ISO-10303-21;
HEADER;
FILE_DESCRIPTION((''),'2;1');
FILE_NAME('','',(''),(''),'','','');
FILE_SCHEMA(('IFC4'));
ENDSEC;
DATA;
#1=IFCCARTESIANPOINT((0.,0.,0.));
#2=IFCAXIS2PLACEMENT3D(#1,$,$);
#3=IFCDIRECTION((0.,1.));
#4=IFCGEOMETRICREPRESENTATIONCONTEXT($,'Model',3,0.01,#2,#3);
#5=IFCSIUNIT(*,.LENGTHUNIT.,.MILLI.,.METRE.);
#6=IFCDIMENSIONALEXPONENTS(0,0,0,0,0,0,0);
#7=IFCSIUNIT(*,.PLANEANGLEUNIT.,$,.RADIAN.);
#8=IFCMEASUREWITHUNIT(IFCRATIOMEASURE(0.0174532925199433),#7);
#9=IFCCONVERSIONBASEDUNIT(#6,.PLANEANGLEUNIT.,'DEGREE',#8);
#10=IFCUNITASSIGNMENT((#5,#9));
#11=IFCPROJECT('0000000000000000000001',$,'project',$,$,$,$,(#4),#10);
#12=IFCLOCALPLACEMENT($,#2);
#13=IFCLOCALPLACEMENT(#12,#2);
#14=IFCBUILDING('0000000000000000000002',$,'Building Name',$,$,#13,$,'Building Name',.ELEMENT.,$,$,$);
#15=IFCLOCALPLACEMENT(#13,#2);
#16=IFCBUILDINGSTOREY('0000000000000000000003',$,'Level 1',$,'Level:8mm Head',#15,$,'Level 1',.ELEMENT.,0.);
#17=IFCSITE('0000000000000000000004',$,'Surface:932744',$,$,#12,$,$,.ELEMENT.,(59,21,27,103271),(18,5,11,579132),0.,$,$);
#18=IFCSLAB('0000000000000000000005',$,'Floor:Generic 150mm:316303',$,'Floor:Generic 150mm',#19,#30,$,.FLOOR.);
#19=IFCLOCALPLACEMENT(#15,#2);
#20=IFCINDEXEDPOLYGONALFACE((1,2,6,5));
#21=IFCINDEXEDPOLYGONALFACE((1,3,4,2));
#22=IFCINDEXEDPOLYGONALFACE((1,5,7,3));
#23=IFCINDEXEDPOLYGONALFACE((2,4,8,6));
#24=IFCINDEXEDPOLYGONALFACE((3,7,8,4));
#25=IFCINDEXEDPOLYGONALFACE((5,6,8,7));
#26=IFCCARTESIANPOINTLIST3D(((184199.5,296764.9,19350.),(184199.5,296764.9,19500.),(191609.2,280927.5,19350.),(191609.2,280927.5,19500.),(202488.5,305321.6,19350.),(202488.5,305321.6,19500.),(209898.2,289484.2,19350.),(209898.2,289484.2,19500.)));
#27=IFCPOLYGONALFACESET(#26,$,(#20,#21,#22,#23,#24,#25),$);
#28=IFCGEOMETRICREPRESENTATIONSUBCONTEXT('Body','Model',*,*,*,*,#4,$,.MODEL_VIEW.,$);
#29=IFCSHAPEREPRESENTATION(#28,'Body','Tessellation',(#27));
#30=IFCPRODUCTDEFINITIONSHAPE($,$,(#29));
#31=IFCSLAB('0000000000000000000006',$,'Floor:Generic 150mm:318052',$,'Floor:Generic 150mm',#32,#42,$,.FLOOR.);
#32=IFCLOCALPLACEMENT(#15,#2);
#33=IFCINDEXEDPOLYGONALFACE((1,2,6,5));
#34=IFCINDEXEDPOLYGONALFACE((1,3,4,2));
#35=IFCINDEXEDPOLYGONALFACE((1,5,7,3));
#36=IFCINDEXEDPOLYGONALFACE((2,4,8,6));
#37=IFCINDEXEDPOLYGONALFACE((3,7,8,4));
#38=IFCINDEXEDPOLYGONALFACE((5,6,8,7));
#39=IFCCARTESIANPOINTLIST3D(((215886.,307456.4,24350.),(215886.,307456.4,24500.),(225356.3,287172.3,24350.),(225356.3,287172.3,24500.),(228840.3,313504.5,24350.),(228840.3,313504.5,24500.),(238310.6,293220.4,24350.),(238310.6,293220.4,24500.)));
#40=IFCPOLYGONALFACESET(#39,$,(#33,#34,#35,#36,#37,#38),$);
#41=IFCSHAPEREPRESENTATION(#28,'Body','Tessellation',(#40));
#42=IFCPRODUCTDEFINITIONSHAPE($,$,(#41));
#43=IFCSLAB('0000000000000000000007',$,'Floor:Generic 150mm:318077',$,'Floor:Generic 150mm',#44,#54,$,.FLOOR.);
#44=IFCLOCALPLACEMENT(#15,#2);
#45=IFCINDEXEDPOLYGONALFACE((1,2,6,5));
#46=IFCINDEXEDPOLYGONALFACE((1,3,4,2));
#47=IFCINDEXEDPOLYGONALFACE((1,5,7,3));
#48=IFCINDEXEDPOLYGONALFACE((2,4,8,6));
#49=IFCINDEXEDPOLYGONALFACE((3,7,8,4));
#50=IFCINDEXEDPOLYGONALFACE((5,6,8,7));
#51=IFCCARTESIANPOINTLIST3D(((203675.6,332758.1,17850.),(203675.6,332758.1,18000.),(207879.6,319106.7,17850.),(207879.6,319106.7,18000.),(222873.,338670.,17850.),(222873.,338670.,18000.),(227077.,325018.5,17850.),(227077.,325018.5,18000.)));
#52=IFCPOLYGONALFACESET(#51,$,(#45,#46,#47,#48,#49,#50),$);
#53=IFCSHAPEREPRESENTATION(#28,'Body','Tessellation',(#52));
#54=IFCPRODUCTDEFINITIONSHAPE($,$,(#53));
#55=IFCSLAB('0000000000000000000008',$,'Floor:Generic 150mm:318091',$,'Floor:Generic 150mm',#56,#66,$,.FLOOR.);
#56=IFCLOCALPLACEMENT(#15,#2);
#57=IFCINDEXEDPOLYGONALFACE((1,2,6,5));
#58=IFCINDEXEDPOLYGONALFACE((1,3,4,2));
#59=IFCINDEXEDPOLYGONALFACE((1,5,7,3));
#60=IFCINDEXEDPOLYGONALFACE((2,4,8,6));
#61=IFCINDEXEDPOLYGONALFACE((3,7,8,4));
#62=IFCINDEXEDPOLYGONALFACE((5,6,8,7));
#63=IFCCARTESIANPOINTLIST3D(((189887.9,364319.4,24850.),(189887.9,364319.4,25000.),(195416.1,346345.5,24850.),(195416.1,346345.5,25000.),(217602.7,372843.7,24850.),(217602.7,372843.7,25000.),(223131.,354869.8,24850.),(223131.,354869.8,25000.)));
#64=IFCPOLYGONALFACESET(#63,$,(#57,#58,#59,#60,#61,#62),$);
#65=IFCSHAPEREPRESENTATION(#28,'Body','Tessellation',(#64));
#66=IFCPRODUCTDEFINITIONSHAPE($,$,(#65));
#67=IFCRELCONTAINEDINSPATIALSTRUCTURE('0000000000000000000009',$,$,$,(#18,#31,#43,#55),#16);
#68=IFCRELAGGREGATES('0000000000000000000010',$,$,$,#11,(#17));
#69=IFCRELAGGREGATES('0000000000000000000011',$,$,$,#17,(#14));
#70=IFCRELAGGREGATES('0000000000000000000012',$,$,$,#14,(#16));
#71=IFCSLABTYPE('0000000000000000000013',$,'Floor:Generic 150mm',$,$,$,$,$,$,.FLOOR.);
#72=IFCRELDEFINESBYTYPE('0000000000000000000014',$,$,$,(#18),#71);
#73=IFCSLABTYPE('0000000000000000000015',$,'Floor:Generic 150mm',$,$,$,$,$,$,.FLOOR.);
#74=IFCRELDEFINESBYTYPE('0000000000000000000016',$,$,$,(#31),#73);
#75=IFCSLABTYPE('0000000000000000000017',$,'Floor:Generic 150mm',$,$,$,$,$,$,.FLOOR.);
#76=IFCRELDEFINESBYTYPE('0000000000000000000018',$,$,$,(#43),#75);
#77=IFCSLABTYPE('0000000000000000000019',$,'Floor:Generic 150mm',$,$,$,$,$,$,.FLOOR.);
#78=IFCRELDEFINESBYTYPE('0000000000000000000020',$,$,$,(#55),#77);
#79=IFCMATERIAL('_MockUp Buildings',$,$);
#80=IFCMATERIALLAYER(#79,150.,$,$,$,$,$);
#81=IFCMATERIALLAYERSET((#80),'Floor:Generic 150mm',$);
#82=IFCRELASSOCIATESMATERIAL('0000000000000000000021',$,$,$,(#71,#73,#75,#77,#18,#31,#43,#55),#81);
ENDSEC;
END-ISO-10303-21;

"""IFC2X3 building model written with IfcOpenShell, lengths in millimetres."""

from ifc_helpers import new_model, entity, si_unit, converted_unit, direction, frame, frame_2d, origin, place, context, subcontext, project, spatial, rectangle, extrude, material, layer, layer_set, layer_usage, type_object, element, save


model = new_model("IFC2X3")

# Units and contexts
model_context = context("Model", 3, precision=0.01, world=origin(), true_north=direction((0.0, 1.0)))
body_context = subcontext(model_context, "Body", "Model", "MODEL_VIEW")
ifc_project = project(units=[si_unit("LENGTHUNIT", "METRE", prefix="MILLI"), converted_unit("PLANEANGLEUNIT", "DEGREE", entity("IfcRatioMeasure", 0.0174532925199433), si_unit("PLANEANGLEUNIT", "RADIAN"), dimensions=[0, 0, 0, 0, 0, 0, 0])], contexts=[model_context])

# Site, building, storey
site_placement = place(None, origin())
site = spatial("IfcSite", under=ifc_project, at=site_placement, Name="Surface:932744", CompositionType="ELEMENT", RefLatitude=(59, 21, 27, 103271), RefLongitude=(18, 5, 11, 579132), RefElevation=0.0)
building_placement = place(site_placement, origin())
building = spatial("IfcBuilding", under=site, at=building_placement, Name="Building Name", LongName="Building Name", CompositionType="ELEMENT")
storey_placement = place(building_placement, origin())
storey = spatial("IfcBuildingStorey", under=building, at=storey_placement, Name="Level 1", ObjectType="Level:8mm Head", LongName="Level 1", CompositionType="ELEMENT", Elevation=0.0)

# Slabs
ifc_material = material(Name="_MockUp Buildings")
ifc_layer = layer(ifc_material, 150.0)
ifc_layer_set = layer_set([ifc_layer], Name="Floor:Generic 150mm")
ifc_layer_usage_1 = layer_usage(ifc_layer_set, "AXIS3", "POSITIVE", 0.0)
slab_type_1 = type_object("IfcSlabType", Name="Floor:Generic 150mm", PredefinedType="FLOOR", material=ifc_layer_set)
slab_1_placement = place(storey_placement, origin())
element("IfcSlab", 1, at=slab_1_placement, inside=storey, type_object=slab_type_1, material=ifc_layer_usage_1, Name="Floor:Generic 150mm:316303", ObjectType="Floor:Generic 150mm", PredefinedType="FLOOR", context=body_context, shape_type="SweptSolid", body=[
    extrude(rectangle(XDim=20191.7, YDim=17485.0, at=frame_2d((0.0, 0.0), x_axis=(1.0, 0.0))), frame((197048.8, 293124.5, 19500.0), z_axis=(0.0, 0.0, -1.0), x_axis=(0.905768, 0.423773, 0.0)), (0.0, 0.0, 1.0), 150.0),
])
ifc_layer_usage_2 = layer_usage(ifc_layer_set, "AXIS3", "POSITIVE", 0.0)
slab_type_2 = type_object("IfcSlabType", Name="Floor:Generic 150mm", PredefinedType="FLOOR", material=ifc_layer_set)
slab_2_placement = place(storey_placement, origin())
element("IfcSlab", 2, at=slab_2_placement, inside=storey, type_object=slab_type_2, material=ifc_layer_usage_2, Name="Floor:Generic 150mm:318052", ObjectType="Floor:Generic 150mm", PredefinedType="FLOOR", context=body_context, shape_type="SweptSolid", body=[
    extrude(rectangle(XDim=22386.0, YDim=14296.7, at=frame_2d((0.0, 0.0), x_axis=(1.0, 0.0))), frame((227098.3, 300338.4, 24500.0), z_axis=(0.0, 0.0, -1.0), x_axis=(0.423046, -0.906108, 0.0)), (0.0, 0.0, 1.0), 150.0),
])
ifc_layer_usage_3 = layer_usage(ifc_layer_set, "AXIS3", "POSITIVE", 0.0)
slab_type_3 = type_object("IfcSlabType", Name="Floor:Generic 150mm", PredefinedType="FLOOR", material=ifc_layer_set)
slab_3_placement = place(storey_placement, origin())
element("IfcSlab", 3, at=slab_3_placement, inside=storey, type_object=slab_type_3, material=ifc_layer_usage_3, Name="Floor:Generic 150mm:318077", ObjectType="Floor:Generic 150mm", PredefinedType="FLOOR", context=body_context, shape_type="SweptSolid", body=[
    extrude(rectangle(XDim=14284.2, YDim=20087.1, at=frame_2d((0.0, 0.0), x_axis=(1.0, 0.0))), frame((215376.3, 328888.3, 18000.0), z_axis=(0.0, 0.0, -1.0), x_axis=(0.294313, -0.955709, 0.0)), (0.0, 0.0, 1.0), 150.0),
])
ifc_layer_usage_4 = layer_usage(ifc_layer_set, "AXIS3", "POSITIVE", 0.0)
slab_type_4 = type_object("IfcSlabType", Name="Floor:Generic 150mm", PredefinedType="FLOOR", material=ifc_layer_set)
slab_4_placement = place(storey_placement, origin())
element("IfcSlab", 4, at=slab_4_placement, inside=storey, type_object=slab_type_4, material=ifc_layer_usage_4, Name="Floor:Generic 150mm:318091", ObjectType="Floor:Generic 150mm", PredefinedType="FLOOR", context=body_context, shape_type="SweptSolid", body=[
    extrude(rectangle(XDim=28996.2, YDim=18804.8, at=frame_2d((0.0, 0.0), x_axis=(1.0, 0.0))), frame((206509.4, 359594.6, 25000.0), z_axis=(0.0, 0.0, -1.0), x_axis=(0.955811, 0.29398, 0.0)), (0.0, 0.0, 1.0), 150.0),
])

save(model, "model.ifc")
